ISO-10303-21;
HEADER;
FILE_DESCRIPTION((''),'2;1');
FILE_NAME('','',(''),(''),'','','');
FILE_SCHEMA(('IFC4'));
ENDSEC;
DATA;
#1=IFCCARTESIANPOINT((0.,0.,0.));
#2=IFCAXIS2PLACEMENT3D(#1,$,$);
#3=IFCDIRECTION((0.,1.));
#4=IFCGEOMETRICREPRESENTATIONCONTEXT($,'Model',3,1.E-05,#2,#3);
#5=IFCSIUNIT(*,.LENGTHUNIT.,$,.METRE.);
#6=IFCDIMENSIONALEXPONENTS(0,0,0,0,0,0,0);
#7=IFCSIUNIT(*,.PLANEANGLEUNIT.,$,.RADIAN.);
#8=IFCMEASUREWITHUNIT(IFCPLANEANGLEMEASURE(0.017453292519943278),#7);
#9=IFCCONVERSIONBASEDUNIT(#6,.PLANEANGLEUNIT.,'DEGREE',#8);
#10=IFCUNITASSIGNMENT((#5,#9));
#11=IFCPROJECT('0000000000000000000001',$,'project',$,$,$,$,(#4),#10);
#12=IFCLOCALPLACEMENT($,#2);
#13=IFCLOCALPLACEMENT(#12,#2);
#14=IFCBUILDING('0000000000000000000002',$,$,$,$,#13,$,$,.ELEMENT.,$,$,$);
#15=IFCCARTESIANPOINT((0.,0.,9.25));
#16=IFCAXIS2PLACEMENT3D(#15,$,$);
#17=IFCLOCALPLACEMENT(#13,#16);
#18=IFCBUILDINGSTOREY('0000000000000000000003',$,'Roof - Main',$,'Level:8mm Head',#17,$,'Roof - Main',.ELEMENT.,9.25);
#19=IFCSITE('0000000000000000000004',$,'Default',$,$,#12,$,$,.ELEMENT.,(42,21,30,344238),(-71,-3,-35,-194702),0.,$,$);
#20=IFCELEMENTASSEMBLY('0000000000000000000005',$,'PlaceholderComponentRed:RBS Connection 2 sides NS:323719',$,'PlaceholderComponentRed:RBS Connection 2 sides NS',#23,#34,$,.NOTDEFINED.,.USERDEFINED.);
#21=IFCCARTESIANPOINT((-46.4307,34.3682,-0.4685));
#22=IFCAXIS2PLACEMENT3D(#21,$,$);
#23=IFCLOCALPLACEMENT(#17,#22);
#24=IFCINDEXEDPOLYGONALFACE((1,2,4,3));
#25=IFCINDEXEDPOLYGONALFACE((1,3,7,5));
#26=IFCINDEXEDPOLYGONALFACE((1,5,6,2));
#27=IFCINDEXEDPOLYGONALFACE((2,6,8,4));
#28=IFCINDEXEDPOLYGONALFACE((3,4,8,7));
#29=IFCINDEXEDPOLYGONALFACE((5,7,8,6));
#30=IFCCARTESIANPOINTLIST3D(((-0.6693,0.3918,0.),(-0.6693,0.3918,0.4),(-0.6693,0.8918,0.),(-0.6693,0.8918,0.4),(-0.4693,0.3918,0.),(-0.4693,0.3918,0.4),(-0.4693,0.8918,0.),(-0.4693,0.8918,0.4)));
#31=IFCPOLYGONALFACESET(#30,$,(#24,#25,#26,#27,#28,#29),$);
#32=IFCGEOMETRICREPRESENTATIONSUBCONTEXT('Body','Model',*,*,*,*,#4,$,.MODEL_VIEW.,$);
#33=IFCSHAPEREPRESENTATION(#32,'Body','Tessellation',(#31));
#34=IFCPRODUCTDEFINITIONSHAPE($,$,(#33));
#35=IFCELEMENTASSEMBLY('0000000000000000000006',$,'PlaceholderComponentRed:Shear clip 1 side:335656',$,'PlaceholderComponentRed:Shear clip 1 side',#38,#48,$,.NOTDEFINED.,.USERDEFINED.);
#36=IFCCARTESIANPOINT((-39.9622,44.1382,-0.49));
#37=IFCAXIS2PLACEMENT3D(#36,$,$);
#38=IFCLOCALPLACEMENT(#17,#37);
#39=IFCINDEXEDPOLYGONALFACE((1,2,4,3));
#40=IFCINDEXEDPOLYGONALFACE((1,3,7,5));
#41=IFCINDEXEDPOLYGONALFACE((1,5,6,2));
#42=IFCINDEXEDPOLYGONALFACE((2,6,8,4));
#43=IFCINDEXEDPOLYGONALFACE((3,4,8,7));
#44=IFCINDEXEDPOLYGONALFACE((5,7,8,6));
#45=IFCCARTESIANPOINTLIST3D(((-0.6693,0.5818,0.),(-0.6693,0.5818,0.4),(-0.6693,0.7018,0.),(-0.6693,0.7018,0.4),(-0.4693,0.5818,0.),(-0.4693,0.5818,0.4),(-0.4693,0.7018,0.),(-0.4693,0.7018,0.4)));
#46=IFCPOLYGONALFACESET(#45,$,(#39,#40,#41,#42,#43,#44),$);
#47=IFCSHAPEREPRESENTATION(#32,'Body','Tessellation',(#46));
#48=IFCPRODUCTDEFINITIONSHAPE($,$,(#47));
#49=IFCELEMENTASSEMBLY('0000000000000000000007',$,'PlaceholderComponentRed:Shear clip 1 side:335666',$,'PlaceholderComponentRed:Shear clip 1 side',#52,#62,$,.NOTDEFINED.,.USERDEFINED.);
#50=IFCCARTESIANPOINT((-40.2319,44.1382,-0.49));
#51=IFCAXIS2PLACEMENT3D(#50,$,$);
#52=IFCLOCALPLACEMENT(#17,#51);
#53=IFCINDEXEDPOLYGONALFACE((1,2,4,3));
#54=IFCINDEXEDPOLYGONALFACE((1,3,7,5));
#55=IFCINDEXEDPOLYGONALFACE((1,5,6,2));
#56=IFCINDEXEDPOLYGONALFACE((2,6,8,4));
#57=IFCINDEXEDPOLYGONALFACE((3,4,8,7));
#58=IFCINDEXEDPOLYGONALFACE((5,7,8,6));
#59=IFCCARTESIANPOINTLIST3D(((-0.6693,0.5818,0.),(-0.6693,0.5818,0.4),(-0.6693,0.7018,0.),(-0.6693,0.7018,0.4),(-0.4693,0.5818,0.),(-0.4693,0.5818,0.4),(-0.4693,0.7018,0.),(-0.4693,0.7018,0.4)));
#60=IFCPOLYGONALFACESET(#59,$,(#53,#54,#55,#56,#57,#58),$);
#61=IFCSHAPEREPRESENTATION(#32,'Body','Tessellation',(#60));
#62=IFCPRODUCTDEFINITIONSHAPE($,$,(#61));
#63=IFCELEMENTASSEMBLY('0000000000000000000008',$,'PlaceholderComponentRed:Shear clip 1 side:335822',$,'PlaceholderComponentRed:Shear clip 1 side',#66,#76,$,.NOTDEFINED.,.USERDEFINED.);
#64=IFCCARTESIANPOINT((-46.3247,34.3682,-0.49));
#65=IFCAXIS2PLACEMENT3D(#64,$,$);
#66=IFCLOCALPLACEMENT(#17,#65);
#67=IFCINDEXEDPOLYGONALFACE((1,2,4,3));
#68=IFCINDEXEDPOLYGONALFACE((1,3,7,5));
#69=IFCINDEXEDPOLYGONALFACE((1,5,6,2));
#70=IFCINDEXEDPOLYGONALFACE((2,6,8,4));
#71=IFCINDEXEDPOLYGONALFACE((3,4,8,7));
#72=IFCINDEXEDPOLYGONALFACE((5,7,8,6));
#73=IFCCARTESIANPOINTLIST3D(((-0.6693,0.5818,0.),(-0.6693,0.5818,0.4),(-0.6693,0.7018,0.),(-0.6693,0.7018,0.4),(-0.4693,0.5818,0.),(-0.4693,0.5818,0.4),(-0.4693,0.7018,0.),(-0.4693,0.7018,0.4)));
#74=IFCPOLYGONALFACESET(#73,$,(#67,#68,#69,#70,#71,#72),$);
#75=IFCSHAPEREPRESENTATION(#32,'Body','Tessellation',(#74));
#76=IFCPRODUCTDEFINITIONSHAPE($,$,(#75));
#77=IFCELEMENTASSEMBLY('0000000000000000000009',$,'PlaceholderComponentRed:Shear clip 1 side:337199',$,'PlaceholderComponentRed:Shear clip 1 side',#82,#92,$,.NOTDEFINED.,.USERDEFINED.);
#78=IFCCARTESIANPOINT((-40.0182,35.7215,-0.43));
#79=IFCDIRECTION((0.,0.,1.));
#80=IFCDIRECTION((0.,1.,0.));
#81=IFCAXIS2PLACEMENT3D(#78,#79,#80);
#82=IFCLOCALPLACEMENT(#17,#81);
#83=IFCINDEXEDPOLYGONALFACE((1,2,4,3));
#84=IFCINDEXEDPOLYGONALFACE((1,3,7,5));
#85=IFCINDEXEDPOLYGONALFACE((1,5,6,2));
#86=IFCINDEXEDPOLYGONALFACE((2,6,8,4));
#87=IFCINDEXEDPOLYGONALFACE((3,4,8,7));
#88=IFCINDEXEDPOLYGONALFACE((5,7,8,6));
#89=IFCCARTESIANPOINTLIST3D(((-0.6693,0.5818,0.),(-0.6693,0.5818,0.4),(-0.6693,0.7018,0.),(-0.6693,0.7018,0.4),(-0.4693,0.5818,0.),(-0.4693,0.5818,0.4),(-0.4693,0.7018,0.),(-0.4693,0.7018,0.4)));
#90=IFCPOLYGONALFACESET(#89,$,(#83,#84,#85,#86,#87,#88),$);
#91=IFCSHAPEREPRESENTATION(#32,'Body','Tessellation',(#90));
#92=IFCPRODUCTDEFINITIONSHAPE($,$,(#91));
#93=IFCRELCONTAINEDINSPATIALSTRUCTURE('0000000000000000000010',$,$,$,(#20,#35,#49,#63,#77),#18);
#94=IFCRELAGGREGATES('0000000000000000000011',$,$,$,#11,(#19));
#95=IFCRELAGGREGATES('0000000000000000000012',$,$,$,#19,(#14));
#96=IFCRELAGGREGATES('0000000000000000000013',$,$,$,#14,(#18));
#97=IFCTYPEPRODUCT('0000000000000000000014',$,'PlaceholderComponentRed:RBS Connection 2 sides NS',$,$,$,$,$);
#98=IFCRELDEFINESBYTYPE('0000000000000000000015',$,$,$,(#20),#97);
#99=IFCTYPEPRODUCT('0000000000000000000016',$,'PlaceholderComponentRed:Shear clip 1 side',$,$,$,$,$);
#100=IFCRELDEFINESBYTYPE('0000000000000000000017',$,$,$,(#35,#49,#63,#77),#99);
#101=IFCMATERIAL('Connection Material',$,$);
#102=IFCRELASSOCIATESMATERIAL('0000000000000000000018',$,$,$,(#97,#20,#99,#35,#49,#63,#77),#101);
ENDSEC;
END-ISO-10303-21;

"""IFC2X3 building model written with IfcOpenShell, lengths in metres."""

from ifc_helpers import new_model, entity, si_unit, converted_unit, direction, frame, frame_2d, origin, place, context, subcontext, project, spatial, rectangle, extrude, source, transform, mapped, material, type_object, type_shapes, element, save


model = new_model("IFC2X3")

# Units and contexts
model_context = context("Model", 3, precision=1e-05, world=origin(), true_north=direction((0.0, 1.0)))
body_context = subcontext(model_context, "Body", "Model", "MODEL_VIEW")
ifc_project = project(units=[si_unit("LENGTHUNIT", "METRE"), converted_unit("PLANEANGLEUNIT", "DEGREE", entity("IfcPlaneAngleMeasure", 0.017453292519943278), si_unit("PLANEANGLEUNIT", "RADIAN"), dimensions=[0, 0, 0, 0, 0, 0, 0])], contexts=[model_context])

# Site, building, storey
site_placement = place(None, origin())
site = spatial("IfcSite", under=ifc_project, at=site_placement, Name="Default", CompositionType="ELEMENT", RefLatitude=(42, 21, 30, 344238), RefLongitude=(-71, -3, -35, -194702), RefElevation=0.0)
building_placement = place(site_placement, origin())
building = spatial("IfcBuilding", under=site, at=building_placement, CompositionType="ELEMENT")
storey_placement = place(building_placement, frame((0.0, 0.0, 9.25)))
storey = spatial("IfcBuildingStorey", under=building, at=storey_placement, Name="Roof - Main", ObjectType="Level:8mm Head", LongName="Roof - Main", CompositionType="ELEMENT", Elevation=9.25)

# Element assemblies
ifc_material_1 = material(Name="Connection Material")
type_product_1 = type_object("IfcTypeProduct", Name="PlaceholderComponentRed:RBS Connection 2 sides NS", material=ifc_material_1)
shared_shape_1 = source(origin(), body_context, "Body", "SweptSolid", [
    extrude(rectangle(XDim=0.5, YDim=0.2, at=frame_2d((0.0, 0.0), x_axis=(1.0, 0.0))), frame((-0.5693, 0.6418, 0.0), z_axis=(0.0, 0.0, 1.0), x_axis=(0.0, 1.0, 0.0)), (0.0, 0.0, 1.0), 0.4),
])
type_shapes(type_product_1, [shared_shape_1])
assembly_1_placement = place(storey_placement, frame((-46.4307, 34.3682, -0.4685)))
element("IfcElementAssembly", 1, at=assembly_1_placement, inside=storey, type_object=type_product_1, material=ifc_material_1, Name="PlaceholderComponentRed:RBS Connection 2 sides NS:323719", ObjectType="PlaceholderComponentRed:RBS Connection 2 sides NS", AssemblyPlace="NOTDEFINED", PredefinedType="USERDEFINED", context=body_context, shape_type="MappedRepresentation", body=[
    mapped(shared_shape_1, transform((0.0, 0.0, 0.0), scale=1.0)),
])
type_product_2 = type_object("IfcTypeProduct", Name="PlaceholderComponentRed:Shear clip 1 side", material=ifc_material_1)
shared_shape_2 = source(origin(), body_context, "Body", "SweptSolid", [
    extrude(rectangle(XDim=0.12, YDim=0.2, at=frame_2d((0.0, 0.0), x_axis=(1.0, 0.0))), frame((-0.5693, 0.6418, 0.0), z_axis=(0.0, 0.0, 1.0), x_axis=(0.0, 1.0, 0.0)), (0.0, 0.0, 1.0), 0.4),
])
type_shapes(type_product_2, [shared_shape_2])
for number, where, name in (
    (2, (-39.9622, 44.1382, -0.49), "PlaceholderComponentRed:Shear clip 1 side:335656"),
    (3, (-40.2319, 44.1382, -0.49), "PlaceholderComponentRed:Shear clip 1 side:335666"),
    (4, (-46.3247, 34.3682, -0.49), "PlaceholderComponentRed:Shear clip 1 side:335822"),
):
    element("IfcElementAssembly", number, at=place(storey_placement, frame(where)), inside=storey, type_object=type_product_2, material=ifc_material_1, Name=name, ObjectType="PlaceholderComponentRed:Shear clip 1 side", AssemblyPlace="NOTDEFINED", PredefinedType="USERDEFINED", context=body_context, shape_type="MappedRepresentation", body=[
        mapped(shared_shape_2, transform((0.0, 0.0, 0.0), scale=1.0)),
    ])
assembly_2_placement = place(storey_placement, frame((-40.0182, 35.7215, -0.43), z_axis=(0.0, 0.0, 1.0), x_axis=(0.0, 1.0, 0.0)))
element("IfcElementAssembly", 5, at=assembly_2_placement, inside=storey, type_object=type_product_2, material=ifc_material_1, Name="PlaceholderComponentRed:Shear clip 1 side:337199", ObjectType="PlaceholderComponentRed:Shear clip 1 side", AssemblyPlace="NOTDEFINED", PredefinedType="USERDEFINED", context=body_context, shape_type="MappedRepresentation", body=[
    mapped(shared_shape_2, transform((0.0, 0.0, 0.0), scale=1.0)),
])

save(model, "model.ifc")
